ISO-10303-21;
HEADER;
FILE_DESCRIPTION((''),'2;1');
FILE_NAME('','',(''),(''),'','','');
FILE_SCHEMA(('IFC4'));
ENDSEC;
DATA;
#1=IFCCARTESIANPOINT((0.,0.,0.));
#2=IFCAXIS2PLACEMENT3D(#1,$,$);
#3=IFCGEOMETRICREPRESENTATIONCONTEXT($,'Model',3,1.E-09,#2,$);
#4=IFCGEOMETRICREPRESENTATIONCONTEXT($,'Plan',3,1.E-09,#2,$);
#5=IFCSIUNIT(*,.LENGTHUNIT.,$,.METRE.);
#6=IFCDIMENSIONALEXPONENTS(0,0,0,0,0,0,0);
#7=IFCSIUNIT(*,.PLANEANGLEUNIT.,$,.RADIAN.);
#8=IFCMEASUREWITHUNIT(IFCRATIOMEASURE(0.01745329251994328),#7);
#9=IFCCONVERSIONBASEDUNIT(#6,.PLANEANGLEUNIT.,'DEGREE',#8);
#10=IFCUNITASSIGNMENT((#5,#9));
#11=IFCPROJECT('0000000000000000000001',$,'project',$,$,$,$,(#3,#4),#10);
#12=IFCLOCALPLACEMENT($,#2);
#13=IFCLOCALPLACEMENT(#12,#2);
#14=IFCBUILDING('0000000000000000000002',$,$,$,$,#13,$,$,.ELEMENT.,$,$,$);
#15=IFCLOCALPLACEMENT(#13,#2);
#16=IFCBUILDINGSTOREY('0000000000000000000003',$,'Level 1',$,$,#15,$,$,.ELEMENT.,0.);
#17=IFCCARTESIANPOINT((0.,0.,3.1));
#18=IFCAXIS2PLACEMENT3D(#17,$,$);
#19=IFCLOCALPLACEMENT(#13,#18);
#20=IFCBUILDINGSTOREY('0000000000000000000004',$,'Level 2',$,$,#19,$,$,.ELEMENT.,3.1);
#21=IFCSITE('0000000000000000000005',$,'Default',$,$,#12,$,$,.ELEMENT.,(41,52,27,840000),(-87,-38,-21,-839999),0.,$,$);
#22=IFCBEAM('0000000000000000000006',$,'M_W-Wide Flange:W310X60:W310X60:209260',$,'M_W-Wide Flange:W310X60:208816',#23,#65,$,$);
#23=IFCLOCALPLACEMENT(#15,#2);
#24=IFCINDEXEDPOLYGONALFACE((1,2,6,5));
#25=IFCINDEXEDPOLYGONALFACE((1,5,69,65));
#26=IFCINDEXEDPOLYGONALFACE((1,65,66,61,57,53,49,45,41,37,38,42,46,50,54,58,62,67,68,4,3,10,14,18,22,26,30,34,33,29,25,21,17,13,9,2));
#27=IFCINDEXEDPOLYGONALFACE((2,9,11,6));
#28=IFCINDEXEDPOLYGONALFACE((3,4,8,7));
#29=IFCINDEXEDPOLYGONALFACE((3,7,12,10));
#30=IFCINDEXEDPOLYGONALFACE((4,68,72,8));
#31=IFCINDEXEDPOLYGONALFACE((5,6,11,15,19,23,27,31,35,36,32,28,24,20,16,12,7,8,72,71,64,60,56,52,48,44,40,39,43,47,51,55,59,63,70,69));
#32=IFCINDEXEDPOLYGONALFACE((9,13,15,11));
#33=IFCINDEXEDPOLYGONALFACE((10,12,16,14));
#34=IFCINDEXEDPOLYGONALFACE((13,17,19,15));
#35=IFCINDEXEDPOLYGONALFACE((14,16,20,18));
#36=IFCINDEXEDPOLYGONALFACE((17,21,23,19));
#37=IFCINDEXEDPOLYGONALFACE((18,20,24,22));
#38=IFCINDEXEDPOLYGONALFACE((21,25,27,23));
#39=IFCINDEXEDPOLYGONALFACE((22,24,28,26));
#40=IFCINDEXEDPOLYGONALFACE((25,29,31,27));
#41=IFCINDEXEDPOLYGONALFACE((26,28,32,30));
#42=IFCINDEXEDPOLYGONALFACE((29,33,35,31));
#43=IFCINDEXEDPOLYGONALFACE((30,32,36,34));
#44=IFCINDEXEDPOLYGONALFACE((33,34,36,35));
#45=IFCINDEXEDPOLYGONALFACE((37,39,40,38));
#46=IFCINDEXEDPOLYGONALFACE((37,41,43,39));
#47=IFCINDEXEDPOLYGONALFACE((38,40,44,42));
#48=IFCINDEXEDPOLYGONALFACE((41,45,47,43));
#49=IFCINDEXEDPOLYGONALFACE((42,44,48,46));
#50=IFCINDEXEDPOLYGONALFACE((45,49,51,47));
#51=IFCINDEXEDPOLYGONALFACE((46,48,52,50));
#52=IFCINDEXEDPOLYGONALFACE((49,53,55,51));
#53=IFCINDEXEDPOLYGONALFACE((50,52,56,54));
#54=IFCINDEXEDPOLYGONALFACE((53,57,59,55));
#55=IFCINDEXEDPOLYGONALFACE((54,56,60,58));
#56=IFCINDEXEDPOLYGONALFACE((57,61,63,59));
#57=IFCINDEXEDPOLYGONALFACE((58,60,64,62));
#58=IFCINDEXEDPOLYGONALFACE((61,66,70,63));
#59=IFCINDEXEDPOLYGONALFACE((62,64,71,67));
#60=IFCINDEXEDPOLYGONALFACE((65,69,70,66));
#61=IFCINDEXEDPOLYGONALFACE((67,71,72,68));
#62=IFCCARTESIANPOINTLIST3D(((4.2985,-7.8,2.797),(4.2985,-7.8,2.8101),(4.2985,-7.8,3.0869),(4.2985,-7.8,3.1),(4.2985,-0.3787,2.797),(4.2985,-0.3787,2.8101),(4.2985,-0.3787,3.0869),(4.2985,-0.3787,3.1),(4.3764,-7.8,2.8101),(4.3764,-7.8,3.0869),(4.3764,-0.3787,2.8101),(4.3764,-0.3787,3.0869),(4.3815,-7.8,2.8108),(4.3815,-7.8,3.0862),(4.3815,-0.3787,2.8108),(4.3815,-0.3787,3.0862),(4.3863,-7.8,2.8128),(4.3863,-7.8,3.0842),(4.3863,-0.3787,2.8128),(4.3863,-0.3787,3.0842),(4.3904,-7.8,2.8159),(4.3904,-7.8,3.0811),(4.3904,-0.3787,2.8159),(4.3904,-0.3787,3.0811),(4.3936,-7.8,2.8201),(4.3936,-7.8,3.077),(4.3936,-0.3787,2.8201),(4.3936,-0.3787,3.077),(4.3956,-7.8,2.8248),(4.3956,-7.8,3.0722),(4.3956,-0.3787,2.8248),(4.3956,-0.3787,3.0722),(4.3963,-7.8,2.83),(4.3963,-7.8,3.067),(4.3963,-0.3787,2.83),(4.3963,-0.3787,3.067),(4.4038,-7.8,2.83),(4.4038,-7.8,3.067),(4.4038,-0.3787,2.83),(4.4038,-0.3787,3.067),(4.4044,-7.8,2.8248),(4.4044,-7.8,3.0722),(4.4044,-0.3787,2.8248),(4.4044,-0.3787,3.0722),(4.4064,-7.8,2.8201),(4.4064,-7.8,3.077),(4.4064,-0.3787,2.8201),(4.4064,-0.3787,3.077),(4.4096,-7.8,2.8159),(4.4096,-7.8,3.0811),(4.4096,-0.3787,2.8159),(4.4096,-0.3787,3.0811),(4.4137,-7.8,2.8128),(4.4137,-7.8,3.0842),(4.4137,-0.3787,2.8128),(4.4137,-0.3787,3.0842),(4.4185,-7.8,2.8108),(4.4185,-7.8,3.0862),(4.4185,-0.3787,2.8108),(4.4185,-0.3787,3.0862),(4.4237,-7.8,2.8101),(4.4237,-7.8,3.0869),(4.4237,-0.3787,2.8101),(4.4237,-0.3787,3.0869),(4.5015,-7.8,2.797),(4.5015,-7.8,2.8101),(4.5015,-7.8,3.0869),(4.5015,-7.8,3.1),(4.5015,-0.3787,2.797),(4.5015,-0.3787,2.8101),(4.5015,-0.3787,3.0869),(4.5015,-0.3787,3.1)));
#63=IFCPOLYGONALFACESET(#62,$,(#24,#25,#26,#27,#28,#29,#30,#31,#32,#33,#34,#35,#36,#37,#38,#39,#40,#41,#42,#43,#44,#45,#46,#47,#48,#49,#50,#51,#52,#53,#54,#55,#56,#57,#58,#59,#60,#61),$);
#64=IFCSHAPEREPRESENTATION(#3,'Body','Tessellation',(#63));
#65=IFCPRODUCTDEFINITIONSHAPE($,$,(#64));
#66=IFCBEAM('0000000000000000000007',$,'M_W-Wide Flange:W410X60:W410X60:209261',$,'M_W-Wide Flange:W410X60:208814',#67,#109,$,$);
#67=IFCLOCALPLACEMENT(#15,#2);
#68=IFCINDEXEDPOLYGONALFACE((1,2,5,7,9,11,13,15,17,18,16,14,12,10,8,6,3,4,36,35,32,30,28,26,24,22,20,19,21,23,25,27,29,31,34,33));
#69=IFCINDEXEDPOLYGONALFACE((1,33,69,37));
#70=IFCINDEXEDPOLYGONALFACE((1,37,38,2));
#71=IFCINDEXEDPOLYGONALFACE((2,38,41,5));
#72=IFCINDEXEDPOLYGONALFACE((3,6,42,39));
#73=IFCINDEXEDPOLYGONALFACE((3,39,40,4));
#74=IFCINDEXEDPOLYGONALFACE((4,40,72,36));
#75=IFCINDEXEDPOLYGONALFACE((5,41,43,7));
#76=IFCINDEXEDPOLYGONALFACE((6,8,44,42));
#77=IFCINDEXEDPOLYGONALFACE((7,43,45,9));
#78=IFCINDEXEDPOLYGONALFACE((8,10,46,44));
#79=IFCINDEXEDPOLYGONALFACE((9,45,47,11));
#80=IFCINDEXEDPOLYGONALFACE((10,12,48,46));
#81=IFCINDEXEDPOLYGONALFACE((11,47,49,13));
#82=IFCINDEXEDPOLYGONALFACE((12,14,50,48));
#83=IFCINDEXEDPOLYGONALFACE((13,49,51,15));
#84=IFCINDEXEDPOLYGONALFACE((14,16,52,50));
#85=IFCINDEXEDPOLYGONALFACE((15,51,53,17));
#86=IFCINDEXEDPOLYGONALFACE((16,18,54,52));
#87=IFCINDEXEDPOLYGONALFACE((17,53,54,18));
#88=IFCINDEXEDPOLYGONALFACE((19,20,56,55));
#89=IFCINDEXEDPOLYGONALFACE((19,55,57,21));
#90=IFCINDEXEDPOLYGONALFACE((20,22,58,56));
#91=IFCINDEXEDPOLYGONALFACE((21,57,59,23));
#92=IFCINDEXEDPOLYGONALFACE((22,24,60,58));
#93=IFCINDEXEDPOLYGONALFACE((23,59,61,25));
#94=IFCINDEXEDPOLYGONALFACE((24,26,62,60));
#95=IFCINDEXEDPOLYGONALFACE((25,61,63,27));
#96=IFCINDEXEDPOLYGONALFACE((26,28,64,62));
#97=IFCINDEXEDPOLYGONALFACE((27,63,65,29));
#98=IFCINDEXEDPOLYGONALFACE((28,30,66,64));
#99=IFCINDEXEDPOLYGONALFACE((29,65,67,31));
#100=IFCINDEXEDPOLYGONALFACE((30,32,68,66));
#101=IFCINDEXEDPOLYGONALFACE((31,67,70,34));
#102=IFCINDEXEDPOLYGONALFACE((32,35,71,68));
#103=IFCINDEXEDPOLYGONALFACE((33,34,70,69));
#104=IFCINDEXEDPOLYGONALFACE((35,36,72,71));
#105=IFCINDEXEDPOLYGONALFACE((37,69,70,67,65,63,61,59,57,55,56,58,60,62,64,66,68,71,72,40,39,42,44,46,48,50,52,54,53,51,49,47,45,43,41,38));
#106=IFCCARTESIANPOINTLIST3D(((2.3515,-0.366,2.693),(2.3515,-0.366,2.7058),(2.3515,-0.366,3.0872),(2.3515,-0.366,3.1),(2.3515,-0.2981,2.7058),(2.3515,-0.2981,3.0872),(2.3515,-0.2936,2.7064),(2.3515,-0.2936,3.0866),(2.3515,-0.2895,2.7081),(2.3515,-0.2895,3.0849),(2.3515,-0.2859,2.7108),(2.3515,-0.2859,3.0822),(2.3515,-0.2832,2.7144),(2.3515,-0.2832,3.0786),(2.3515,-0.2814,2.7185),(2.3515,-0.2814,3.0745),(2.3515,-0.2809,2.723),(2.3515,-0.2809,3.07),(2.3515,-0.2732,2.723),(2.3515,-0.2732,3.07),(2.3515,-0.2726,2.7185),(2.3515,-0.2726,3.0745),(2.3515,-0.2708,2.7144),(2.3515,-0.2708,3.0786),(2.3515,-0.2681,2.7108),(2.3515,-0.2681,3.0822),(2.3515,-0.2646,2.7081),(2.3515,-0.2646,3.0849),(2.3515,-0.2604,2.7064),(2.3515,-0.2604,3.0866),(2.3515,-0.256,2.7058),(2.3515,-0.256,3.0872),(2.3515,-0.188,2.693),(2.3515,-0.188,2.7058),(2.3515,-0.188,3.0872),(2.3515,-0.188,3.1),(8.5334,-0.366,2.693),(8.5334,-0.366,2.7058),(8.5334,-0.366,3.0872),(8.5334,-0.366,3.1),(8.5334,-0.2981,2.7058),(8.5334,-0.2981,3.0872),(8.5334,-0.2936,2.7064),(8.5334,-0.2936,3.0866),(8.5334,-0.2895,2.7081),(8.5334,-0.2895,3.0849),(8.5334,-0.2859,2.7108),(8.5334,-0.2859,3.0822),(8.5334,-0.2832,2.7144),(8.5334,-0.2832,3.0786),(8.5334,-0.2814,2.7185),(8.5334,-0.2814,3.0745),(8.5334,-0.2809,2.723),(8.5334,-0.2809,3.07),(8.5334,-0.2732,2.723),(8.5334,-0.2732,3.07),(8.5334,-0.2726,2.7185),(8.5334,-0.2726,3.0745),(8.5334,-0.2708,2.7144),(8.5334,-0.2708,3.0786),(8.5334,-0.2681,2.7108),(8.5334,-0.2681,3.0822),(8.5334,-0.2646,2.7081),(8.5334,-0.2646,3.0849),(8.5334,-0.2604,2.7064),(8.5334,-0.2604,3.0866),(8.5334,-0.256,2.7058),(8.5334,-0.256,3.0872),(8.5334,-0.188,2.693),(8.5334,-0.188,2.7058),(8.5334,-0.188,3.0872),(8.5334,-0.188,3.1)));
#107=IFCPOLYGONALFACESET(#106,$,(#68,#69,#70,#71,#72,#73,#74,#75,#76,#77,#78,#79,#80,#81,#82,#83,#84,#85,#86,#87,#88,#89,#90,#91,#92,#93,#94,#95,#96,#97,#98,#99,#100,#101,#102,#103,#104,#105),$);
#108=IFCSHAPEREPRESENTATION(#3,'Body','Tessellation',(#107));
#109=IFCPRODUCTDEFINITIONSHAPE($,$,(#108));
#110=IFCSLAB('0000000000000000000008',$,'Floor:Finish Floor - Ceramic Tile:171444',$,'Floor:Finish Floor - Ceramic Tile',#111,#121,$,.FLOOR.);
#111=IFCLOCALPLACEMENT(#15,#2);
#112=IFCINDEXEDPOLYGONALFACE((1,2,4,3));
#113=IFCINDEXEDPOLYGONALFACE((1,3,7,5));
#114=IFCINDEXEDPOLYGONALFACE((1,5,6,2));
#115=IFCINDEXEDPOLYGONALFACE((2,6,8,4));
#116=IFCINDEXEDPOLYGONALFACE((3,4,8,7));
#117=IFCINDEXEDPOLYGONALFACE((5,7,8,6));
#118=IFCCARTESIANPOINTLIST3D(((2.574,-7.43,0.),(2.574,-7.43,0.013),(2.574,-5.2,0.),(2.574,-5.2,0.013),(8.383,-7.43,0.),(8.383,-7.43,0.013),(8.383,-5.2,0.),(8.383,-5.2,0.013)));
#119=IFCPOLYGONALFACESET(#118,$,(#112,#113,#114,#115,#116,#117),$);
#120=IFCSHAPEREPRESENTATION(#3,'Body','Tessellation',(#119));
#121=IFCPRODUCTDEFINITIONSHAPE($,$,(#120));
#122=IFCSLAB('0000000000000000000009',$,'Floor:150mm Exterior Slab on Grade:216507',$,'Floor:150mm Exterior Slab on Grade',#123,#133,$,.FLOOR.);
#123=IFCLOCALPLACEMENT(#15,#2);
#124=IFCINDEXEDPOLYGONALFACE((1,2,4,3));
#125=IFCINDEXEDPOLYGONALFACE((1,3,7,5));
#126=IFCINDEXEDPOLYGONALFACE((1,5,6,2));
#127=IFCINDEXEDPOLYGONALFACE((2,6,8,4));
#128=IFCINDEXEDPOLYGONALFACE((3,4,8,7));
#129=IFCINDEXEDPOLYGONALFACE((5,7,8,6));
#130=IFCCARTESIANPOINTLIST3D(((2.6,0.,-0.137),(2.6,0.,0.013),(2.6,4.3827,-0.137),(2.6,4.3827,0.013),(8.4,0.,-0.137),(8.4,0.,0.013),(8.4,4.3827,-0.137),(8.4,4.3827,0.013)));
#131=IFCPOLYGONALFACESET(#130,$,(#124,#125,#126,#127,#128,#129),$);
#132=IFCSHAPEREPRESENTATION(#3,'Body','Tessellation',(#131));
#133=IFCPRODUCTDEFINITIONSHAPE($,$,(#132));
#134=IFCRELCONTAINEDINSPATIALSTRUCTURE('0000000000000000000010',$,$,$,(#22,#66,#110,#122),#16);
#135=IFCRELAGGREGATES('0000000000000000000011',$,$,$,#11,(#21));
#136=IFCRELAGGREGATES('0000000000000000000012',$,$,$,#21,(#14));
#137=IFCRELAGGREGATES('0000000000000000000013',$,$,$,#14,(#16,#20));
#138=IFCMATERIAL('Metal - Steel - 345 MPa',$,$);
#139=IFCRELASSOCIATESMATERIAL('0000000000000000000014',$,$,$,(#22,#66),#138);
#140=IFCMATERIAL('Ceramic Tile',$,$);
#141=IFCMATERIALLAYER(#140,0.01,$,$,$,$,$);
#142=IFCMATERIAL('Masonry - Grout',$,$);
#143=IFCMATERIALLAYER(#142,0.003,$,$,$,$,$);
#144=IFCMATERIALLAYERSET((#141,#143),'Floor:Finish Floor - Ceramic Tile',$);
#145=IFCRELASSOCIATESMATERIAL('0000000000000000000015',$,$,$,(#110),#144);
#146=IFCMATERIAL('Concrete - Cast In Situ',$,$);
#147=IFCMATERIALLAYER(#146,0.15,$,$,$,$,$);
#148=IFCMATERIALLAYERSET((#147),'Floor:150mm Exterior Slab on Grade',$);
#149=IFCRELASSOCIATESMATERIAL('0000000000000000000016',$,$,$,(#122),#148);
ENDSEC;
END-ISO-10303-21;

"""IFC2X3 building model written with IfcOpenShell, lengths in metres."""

from ifc_helpers import new_model, entity, si_unit, converted_unit, frame, frame_2d, origin, place, context, project, spatial, polyline, circle_curve, parameter, trimmed, segment, composite_curve, rectangle, outline, extrude, material, layer, layer_set, layer_usage, element, save


model = new_model("IFC2X3")

# Units and contexts
model_context = context("Model", 3, precision=1e-09, world=origin())
plan_context = context("Plan", 3, precision=1e-09, world=origin())
ifc_project = project(units=[si_unit("LENGTHUNIT", "METRE"), converted_unit("PLANEANGLEUNIT", "DEGREE", entity("IfcRatioMeasure", 0.01745329251994328), si_unit("PLANEANGLEUNIT", "RADIAN"), dimensions=[0, 0, 0, 0, 0, 0, 0])], contexts=[model_context, plan_context])

# Site, building, storey
site_placement = place(None, origin())
site = spatial("IfcSite", under=ifc_project, at=site_placement, Name="Default", CompositionType="ELEMENT", RefLatitude=(41, 52, 27, 840000), RefLongitude=(-87, -38, -21, -839999), RefElevation=0.0)
building_placement = place(site_placement, origin())
building = spatial("IfcBuilding", under=site, at=building_placement, CompositionType="ELEMENT")
storey_1_placement = place(building_placement, origin())
storey_1 = spatial("IfcBuildingStorey", under=building, at=storey_1_placement, Name="Level 1", CompositionType="ELEMENT", Elevation=0.0)

# Beams
ifc_material_1 = material(Name="Metal - Steel - 345 MPa")
beam_1_placement = place(storey_1_placement, frame((4.4, -7.8, 3.1)))
element("IfcBeam", 1, at=beam_1_placement, inside=storey_1, material=ifc_material_1, Name="M_W-Wide Flange:W310X60:W310X60:209260", ObjectType="M_W-Wide Flange:W310X60:208816", context=model_context, shape_type="SweptSolid", body=[
    extrude(outline(composite_curve([segment(polyline([(-0.1015, -0.1384), (-0.1015, -0.1515)]), True, "CONTINUOUS"), segment(polyline([(-0.1015, -0.1515), (0.1015, -0.1515)]), True, "CONTINUOUS"), segment(polyline([(0.1015, -0.1515), (0.1015, -0.1384)]), True, "CONTINUOUS"), segment(polyline([(0.1015, -0.1384), (0.0236, -0.1384)]), True, "CONTINUOUS"), segment(trimmed(circle_curve(frame_2d((0.0236, -0.1185), x_axis=(1.0, 0.0)), 0.0199), [parameter(180.0)], [parameter(270.0)], True, "PARAMETER"), False, "CONTINUOUS"), segment(polyline([(0.0037, -0.1185), (0.0037, 0.1185)]), True, "CONTINUOUS"), segment(trimmed(circle_curve(frame_2d((0.0236, 0.1185), x_axis=(1.0, 0.0)), 0.0199), [parameter(90.0)], [parameter(180.0)], True, "PARAMETER"), False, "CONTINUOUS"), segment(polyline([(0.0236, 0.1384), (0.1015, 0.1384)]), True, "CONTINUOUS"), segment(polyline([(0.1015, 0.1384), (0.1015, 0.1515)]), True, "CONTINUOUS"), segment(polyline([(0.1015, 0.1515), (-0.1015, 0.1515)]), True, "CONTINUOUS"), segment(polyline([(-0.1015, 0.1515), (-0.1015, 0.1384)]), True, "CONTINUOUS"), segment(polyline([(-0.1015, 0.1384), (-0.0237, 0.1384)]), True, "CONTINUOUS"), segment(trimmed(circle_curve(frame_2d((-0.0237, 0.1185), x_axis=(1.0, 0.0)), 0.0199), [parameter(360.0)], [parameter(90.0)], True, "PARAMETER"), False, "CONTINUOUS"), segment(polyline([(-0.0038, 0.1185), (-0.0038, -0.1185)]), True, "CONTINUOUS"), segment(trimmed(circle_curve(frame_2d((-0.0237, -0.1185), x_axis=(1.0, 0.0)), 0.0199), [parameter(270.0)], [parameter(0.0)], True, "PARAMETER"), False, "CONTINUOUS"), segment(polyline([(-0.0237, -0.1384), (-0.1015, -0.1384)]), True, "CONTINUOUS")], self_intersect=False)), frame((0.0, 0.0, -0.1515), z_axis=(0.0, -1.0, 0.0), x_axis=(1.0, 0.0, 0.0)), (0.0, 0.0, -1.0), 7.4213),
])
beam_2_placement = place(storey_1_placement, frame((8.5915, -0.277, 3.1), z_axis=(0.0, 0.0, 1.0), x_axis=(0.0, 1.0, 0.0)))
element("IfcBeam", 2, at=beam_2_placement, inside=storey_1, material=ifc_material_1, Name="M_W-Wide Flange:W410X60:W410X60:209261", ObjectType="M_W-Wide Flange:W410X60:208814", context=model_context, shape_type="SweptSolid", body=[
    extrude(outline(composite_curve([segment(polyline([(0.1907, -0.089), (0.2035, -0.089)]), True, "CONTINUOUS"), segment(polyline([(0.2035, -0.089), (0.2035, 0.089)]), True, "CONTINUOUS"), segment(polyline([(0.2035, 0.089), (0.1907, 0.089)]), True, "CONTINUOUS"), segment(polyline([(0.1907, 0.089), (0.1907, 0.021)]), True, "CONTINUOUS"), segment(trimmed(circle_curve(frame_2d((0.1735, 0.021), x_axis=(1.0, 0.0)), 0.0172), [parameter(270.0)], [parameter(360.0)], True, "PARAMETER"), False, "CONTINUOUS"), segment(polyline([(0.1735, 0.0038), (-0.1735, 0.0038)]), True, "CONTINUOUS"), segment(trimmed(circle_curve(frame_2d((-0.1735, 0.021), x_axis=(0.0, -1.0)), 0.0172), [parameter(270.0)], [parameter(360.0)], True, "PARAMETER"), False, "CONTINUOUS"), segment(polyline([(-0.1907, 0.021), (-0.1907, 0.089)]), True, "CONTINUOUS"), segment(polyline([(-0.1907, 0.089), (-0.2035, 0.089)]), True, "CONTINUOUS"), segment(polyline([(-0.2035, 0.089), (-0.2035, -0.089)]), True, "CONTINUOUS"), segment(polyline([(-0.2035, -0.089), (-0.1907, -0.089)]), True, "CONTINUOUS"), segment(polyline([(-0.1907, -0.089), (-0.1907, -0.0211)]), True, "CONTINUOUS"), segment(trimmed(circle_curve(frame_2d((-0.1735, -0.0211), x_axis=(-1.0, 0.0)), 0.0172), [parameter(270.0)], [parameter(0.0)], True, "PARAMETER"), False, "CONTINUOUS"), segment(polyline([(-0.1735, -0.0039), (0.1735, -0.0039)]), True, "CONTINUOUS"), segment(trimmed(circle_curve(frame_2d((0.1735, -0.0211), x_axis=(0.0, 1.0)), 0.0172), [parameter(270.0)], [parameter(0.0)], True, "PARAMETER"), False, "CONTINUOUS"), segment(polyline([(0.1907, -0.0211), (0.1907, -0.089)]), True, "CONTINUOUS")], self_intersect=False)), frame((0.0, 6.24, -0.2035), z_axis=(0.0, -1.0, 0.0), x_axis=(0.0, 0.0, -1.0)), (0.0, 0.0, 1.0), 6.1819),
])

# Slabs
ifc_material_2 = material(Name="Ceramic Tile")
ifc_layer_1 = layer(ifc_material_2, 0.01)
ifc_material_3 = material(Name="Masonry - Grout")
ifc_layer_2 = layer(ifc_material_3, 0.003)
ifc_layer_set_1 = layer_set([ifc_layer_1, ifc_layer_2], Name="Floor:Finish Floor - Ceramic Tile")
ifc_layer_usage_1 = layer_usage(ifc_layer_set_1, "AXIS3", "POSITIVE", 0.0)
slab_1_placement = place(storey_1_placement, frame((2.574, -7.43, 0.0)))
element("IfcSlab", 3, at=slab_1_placement, inside=storey_1, material=ifc_layer_usage_1, Name="Floor:Finish Floor - Ceramic Tile:171444", ObjectType="Floor:Finish Floor - Ceramic Tile", PredefinedType="FLOOR", context=model_context, shape_type="SweptSolid", body=[
    extrude(rectangle(XDim=5.809, YDim=2.23, at=frame_2d((0.0, 0.0), x_axis=(-1.0, 0.0))), frame((2.9045, 1.115, 0.013), z_axis=(0.0, 0.0, -1.0), x_axis=(-1.0, 0.0, 0.0)), (0.0, 0.0, 1.0), 0.013),
])
ifc_material_4 = material(Name="Concrete - Cast In Situ")
ifc_layer_3 = layer(ifc_material_4, 0.15)
ifc_layer_set_2 = layer_set([ifc_layer_3], Name="Floor:150mm Exterior Slab on Grade")
ifc_layer_usage_2 = layer_usage(ifc_layer_set_2, "AXIS3", "POSITIVE", 0.0)
slab_2_placement = place(storey_1_placement, frame((2.6, 0.0, -0.137)))
element("IfcSlab", 4, at=slab_2_placement, inside=storey_1, material=ifc_layer_usage_2, Name="Floor:150mm Exterior Slab on Grade:216507", ObjectType="Floor:150mm Exterior Slab on Grade", PredefinedType="FLOOR", context=model_context, shape_type="SweptSolid", body=[
    extrude(rectangle(XDim=5.8, YDim=4.3827, at=frame_2d((0.0, 0.0), x_axis=(-1.0, 0.0))), frame((2.9, 2.1914, 0.15), z_axis=(0.0, 0.0, -1.0), x_axis=(-1.0, 0.0, 0.0)), (0.0, 0.0, 1.0), 0.15),
])

# Shared definitions
storey_2_placement = place(building_placement, frame((0.0, 0.0, 3.1)))
storey_2 = spatial("IfcBuildingStorey", under=building, at=storey_2_placement, Name="Level 2", CompositionType="ELEMENT", Elevation=3.1)

save(model, "model.ifc")
